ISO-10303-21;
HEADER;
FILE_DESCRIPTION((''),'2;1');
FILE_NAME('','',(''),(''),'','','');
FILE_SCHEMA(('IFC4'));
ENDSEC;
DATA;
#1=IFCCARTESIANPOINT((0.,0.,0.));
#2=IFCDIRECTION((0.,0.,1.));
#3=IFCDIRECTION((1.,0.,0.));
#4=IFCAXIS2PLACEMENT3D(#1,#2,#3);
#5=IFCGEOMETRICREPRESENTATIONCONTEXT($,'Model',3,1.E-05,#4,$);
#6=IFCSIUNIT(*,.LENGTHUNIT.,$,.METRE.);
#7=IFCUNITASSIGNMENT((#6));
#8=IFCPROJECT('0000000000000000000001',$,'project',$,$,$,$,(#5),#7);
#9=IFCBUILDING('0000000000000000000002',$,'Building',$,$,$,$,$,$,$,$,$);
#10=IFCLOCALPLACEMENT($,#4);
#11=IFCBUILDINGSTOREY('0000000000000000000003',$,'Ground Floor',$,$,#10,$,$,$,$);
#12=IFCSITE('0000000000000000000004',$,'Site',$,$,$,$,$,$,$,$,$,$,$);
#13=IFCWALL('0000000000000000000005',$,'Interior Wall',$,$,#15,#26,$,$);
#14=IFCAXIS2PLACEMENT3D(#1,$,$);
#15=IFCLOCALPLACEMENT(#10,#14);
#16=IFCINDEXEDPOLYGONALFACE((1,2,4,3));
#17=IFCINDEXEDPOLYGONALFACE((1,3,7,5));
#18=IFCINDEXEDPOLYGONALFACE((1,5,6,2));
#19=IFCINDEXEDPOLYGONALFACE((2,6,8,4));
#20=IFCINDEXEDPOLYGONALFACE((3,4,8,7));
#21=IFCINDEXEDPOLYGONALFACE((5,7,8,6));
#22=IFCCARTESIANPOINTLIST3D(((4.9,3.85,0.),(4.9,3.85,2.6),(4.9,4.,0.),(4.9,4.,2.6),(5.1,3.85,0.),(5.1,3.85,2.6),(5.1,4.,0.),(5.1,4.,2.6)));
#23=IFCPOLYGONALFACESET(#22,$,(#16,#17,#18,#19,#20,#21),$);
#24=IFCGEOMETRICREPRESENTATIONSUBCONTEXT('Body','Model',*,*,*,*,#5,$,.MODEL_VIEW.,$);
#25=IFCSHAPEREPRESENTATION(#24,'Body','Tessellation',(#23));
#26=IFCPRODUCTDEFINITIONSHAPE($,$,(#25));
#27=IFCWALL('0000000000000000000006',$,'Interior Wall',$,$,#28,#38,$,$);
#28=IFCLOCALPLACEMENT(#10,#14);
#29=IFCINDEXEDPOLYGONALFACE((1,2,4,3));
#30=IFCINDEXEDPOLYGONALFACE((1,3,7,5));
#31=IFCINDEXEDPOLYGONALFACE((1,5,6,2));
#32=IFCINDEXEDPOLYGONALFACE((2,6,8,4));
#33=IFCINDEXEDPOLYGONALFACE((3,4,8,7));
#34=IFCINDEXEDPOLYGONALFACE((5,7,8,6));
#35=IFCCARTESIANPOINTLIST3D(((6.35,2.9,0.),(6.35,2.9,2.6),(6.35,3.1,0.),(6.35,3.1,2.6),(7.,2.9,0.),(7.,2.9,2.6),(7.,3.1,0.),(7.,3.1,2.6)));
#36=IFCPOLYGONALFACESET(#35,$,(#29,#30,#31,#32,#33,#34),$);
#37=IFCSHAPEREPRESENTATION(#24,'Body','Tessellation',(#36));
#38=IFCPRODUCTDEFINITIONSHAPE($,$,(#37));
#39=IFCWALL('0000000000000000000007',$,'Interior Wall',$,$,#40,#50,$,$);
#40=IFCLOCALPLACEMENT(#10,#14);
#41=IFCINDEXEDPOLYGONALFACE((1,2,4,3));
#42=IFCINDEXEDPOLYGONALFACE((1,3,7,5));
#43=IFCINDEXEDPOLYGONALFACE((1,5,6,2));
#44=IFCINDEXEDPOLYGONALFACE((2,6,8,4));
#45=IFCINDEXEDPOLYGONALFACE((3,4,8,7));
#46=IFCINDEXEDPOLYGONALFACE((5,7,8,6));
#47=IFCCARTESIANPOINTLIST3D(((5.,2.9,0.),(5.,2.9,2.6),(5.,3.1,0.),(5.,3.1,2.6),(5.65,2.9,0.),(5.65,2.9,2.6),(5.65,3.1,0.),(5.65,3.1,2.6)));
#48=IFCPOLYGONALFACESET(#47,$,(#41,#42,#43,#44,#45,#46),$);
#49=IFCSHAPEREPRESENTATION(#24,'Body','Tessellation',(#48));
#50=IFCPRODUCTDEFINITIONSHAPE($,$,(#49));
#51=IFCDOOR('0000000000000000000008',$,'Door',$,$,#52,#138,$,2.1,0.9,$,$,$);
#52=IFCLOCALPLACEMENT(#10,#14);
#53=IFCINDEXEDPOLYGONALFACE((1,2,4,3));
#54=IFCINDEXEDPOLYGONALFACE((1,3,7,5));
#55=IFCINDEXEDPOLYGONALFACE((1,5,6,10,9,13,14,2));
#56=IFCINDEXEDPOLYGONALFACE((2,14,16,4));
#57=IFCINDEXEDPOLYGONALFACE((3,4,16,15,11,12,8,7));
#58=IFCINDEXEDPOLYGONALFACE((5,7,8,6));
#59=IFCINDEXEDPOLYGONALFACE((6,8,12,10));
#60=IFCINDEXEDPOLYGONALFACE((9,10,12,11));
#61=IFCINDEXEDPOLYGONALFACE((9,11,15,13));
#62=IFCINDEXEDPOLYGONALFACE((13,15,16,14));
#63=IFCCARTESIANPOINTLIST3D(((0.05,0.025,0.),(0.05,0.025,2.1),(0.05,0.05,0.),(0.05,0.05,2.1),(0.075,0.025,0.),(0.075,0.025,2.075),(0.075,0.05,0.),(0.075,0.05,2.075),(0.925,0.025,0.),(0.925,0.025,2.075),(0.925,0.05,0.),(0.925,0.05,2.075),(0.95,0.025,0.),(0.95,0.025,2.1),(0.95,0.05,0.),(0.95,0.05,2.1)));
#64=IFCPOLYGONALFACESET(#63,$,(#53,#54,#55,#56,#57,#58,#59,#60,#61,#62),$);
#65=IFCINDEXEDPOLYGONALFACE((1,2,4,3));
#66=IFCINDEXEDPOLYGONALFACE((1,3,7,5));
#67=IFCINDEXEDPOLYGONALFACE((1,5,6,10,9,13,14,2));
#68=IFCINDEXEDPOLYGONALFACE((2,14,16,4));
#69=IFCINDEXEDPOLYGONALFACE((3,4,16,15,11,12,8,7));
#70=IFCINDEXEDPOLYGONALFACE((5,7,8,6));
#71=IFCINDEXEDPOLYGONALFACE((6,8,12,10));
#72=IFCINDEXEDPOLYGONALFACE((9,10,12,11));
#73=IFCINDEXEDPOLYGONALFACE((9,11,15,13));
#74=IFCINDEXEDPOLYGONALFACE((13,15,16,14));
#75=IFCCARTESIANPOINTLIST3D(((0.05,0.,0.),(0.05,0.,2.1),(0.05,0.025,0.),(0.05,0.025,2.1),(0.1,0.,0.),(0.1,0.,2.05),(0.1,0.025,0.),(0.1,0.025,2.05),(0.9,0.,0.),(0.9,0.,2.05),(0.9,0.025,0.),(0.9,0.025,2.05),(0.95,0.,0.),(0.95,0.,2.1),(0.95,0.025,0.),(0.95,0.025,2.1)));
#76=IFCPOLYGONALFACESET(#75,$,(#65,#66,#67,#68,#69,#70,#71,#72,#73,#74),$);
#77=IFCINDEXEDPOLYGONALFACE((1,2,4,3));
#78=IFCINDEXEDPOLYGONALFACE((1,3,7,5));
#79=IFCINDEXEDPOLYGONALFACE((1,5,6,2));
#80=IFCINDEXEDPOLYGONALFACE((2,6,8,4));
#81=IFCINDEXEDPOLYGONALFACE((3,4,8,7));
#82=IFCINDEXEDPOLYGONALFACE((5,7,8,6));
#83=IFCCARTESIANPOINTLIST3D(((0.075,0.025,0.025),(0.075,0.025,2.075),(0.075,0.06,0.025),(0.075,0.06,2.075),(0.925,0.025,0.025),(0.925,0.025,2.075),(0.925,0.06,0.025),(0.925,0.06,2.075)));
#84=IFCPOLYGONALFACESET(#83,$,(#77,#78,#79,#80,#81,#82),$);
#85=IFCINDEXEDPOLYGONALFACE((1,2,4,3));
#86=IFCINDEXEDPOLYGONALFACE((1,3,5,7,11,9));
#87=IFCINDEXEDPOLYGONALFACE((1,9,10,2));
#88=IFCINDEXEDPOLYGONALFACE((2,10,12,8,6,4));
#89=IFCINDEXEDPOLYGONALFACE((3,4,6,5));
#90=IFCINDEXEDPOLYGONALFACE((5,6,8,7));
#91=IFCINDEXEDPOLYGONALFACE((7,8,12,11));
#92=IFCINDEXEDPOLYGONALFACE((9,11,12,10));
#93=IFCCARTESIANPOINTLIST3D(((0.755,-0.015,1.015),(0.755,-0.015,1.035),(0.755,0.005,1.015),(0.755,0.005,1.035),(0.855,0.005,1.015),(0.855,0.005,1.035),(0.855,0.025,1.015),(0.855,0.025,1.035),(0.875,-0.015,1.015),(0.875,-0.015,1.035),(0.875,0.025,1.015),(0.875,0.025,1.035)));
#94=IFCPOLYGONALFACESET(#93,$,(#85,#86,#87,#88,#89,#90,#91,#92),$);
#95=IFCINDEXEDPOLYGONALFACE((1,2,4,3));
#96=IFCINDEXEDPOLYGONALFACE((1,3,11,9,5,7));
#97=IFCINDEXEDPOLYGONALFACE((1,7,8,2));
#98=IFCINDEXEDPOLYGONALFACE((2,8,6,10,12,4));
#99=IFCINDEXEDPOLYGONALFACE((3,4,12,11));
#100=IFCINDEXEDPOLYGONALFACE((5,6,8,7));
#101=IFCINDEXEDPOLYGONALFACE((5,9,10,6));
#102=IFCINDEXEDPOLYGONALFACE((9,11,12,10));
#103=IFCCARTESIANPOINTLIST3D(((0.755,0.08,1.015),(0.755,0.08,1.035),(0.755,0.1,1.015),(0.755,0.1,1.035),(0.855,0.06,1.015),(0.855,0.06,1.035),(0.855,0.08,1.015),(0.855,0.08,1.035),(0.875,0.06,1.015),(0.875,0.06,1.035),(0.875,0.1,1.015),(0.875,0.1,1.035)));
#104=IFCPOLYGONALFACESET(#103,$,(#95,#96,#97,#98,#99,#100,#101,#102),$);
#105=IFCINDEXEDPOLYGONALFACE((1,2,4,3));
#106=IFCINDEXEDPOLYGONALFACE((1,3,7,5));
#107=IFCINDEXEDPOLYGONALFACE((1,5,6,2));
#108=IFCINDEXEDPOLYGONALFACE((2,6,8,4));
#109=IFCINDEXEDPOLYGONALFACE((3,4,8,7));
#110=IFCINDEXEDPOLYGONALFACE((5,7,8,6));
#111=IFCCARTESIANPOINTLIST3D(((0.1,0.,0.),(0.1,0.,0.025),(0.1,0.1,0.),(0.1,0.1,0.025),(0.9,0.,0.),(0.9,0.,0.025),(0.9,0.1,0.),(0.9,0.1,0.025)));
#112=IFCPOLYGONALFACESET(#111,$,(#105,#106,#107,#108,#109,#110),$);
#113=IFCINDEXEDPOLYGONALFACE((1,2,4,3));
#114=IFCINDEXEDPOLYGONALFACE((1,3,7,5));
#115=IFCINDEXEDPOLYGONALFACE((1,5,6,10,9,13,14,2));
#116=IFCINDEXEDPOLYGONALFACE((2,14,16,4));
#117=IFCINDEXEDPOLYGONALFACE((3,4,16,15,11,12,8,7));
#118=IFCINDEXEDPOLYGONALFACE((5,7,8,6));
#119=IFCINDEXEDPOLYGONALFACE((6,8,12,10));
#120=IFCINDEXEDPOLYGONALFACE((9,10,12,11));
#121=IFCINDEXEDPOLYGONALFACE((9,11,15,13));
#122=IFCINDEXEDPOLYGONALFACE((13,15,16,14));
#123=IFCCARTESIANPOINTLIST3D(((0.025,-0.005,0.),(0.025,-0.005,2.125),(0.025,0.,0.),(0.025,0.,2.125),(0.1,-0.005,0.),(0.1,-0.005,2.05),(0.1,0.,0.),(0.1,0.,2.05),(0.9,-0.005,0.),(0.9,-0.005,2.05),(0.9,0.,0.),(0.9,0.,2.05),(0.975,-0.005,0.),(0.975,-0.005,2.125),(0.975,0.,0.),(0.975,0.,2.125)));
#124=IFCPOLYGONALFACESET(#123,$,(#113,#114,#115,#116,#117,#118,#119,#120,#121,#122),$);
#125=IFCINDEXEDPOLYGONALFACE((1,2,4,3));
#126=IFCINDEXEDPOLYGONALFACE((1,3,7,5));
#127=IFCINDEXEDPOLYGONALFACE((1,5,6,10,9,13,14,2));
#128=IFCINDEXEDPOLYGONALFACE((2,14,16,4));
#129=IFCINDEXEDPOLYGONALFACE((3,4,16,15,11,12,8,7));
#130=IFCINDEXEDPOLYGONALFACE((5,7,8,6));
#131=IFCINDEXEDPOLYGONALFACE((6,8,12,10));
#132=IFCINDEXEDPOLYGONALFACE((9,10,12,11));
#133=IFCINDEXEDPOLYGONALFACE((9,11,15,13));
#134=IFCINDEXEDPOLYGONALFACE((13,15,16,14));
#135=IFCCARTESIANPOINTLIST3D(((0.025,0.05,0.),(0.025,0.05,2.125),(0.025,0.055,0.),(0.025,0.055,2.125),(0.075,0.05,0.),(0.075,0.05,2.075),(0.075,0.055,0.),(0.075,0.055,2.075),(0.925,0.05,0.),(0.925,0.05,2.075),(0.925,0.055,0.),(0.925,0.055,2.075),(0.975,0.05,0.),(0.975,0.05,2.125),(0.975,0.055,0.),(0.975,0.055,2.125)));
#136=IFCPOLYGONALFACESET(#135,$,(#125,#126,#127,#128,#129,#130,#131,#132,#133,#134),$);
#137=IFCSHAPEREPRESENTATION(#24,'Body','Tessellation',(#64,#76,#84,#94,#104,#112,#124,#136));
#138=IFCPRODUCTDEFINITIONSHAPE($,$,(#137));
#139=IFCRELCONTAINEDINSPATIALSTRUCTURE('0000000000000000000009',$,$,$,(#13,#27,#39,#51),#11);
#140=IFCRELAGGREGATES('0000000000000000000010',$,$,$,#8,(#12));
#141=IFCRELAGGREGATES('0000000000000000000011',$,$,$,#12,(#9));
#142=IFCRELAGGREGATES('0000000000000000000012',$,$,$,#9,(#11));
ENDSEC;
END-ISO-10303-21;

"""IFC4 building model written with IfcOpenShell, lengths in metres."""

from ifc_helpers import new_model, si_unit, frame, origin_with_axes, place, context, subcontext, project, spatial, line, indexed_curve, outline, extrude, element, save


model = new_model("IFC4")

# Units and contexts
model_context = context("Model", 3, precision=1e-05, world=origin_with_axes())
body_context = subcontext(model_context, "Body", "Model", "MODEL_VIEW")
ifc_project = project(units=[si_unit("LENGTHUNIT", "METRE")], contexts=[model_context])

# Site, building, storey
site = spatial("IfcSite", under=ifc_project, Name="Site")
building = spatial("IfcBuilding", under=site, Name="Building")
storey_placement = place(None, origin_with_axes())
storey = spatial("IfcBuildingStorey", under=building, at=storey_placement, Name="Ground Floor")

# Walls
for number, where, z_axis, x_axis, name in (
    (1, (5.0, 3.85, 0.0), (0.0, 0.0, 1.0), (0.0, 1.0, 0.0), "Interior Wall"),
):
    element("IfcWall", number, at=place(storey_placement, frame(where, z_axis=z_axis, x_axis=x_axis)), inside=storey, Name=name, context=body_context, shape_type="SweptSolid", body=[
        extrude(outline(indexed_curve([(0.0, 0.0), (0.0, 0.2), (0.15, 0.2), (0.15, 0.0), (0.0, 0.0)], self_intersect=False)), frame((0.0, -0.1, 0.0), z_axis=(0.0, 0.0, 1.0), x_axis=(1.0, 0.0, 0.0)), (0.0, 0.0, 1.0), 2.6),
    ])
for number, where, z_axis, x_axis, name in (
    (2, (7.0, 3.0, 0.0), (0.0, 0.0, 1.0), (-1.0, 0.0, 0.0), "Interior Wall"),
    (3, (5.65, 3.0, 0.0), (0.0, 0.0, 1.0), (-1.0, 0.0, 0.0), "Interior Wall"),
):
    element("IfcWall", number, at=place(storey_placement, frame(where, z_axis=z_axis, x_axis=x_axis)), inside=storey, Name=name, context=body_context, shape_type="SweptSolid", body=[
        extrude(outline(indexed_curve([(0.0, 0.0), (0.0, 0.2), (0.65, 0.2), (0.65, 0.0), (0.0, 0.0)], self_intersect=False)), frame((0.0, -0.1, 0.0), z_axis=(0.0, 0.0, 1.0), x_axis=(1.0, 0.0, 0.0)), (0.0, 0.0, 1.0), 2.6),
    ])

# Door
door_1_placement = place(storey_placement, frame((0.05, 0.0, 0.0), z_axis=(0.0, 0.0, 1.0), x_axis=(1.0, 0.0, 0.0)))
element("IfcDoor", 4, at=door_1_placement, inside=storey, Name="Door", OverallHeight=2.1, OverallWidth=0.9, context=body_context, shape_type="SweptSolid", body=[
    extrude(outline(indexed_curve([(0.0, 0.0), (0.0, 2.1), (0.9, 2.1), (0.9, 0.0), (0.875, 0.0), (0.875, 2.075), (0.025, 2.075), (0.025, 0.0)], segments=[line(1, 2, 3, 4, 5, 6, 7, 8, 1)])), frame((0.0, 0.025, 0.0), z_axis=(0.0, -1.0, 0.0), x_axis=(1.0, 0.0, 0.0)), (0.0, 0.0, -1.0), 0.025),
    extrude(outline(indexed_curve([(0.0, 0.0), (0.0, 2.1), (0.9, 2.1), (0.9, 0.0), (0.85, 0.0), (0.85, 2.05), (0.05, 2.05), (0.05, 0.0)], segments=[line(1, 2, 3, 4, 5, 6, 7, 8, 1)])), frame((0.0, 0.0, 0.0), z_axis=(0.0, -1.0, 0.0), x_axis=(1.0, 0.0, 0.0)), (0.0, 0.0, -1.0), 0.025),
    extrude(outline(indexed_curve([(0.0, 0.0), (0.85, 0.0), (0.85, 0.035), (0.0, 0.035)], segments=[line(1, 2, 3, 4, 1)])), frame((0.025, 0.025, 0.025), z_axis=(0.0, 0.0, 1.0), x_axis=(1.0, 0.0, 0.0)), (0.0, 0.0, 1.0), 2.05),
    extrude(outline(indexed_curve([(0.0, 0.0), (0.0, -0.04), (-0.12, -0.04), (-0.12, -0.02), (-0.02, -0.02), (-0.02, 0.0)], segments=[line(1, 2, 3, 4, 5, 6, 1)])), frame((0.825, 0.025, 1.015), z_axis=(0.0, 0.0, 1.0), x_axis=(1.0, 0.0, 0.0)), (0.0, 0.0, 1.0), 0.02),
    extrude(outline(indexed_curve([(0.0, 0.0), (0.0, 0.04), (-0.12, 0.04), (-0.12, 0.02), (-0.02, 0.02), (-0.02, 0.0)], segments=[line(1, 2, 3, 4, 5, 6, 1)])), frame((0.825, 0.06, 1.015), z_axis=(0.0, 0.0, 1.0), x_axis=(1.0, 0.0, 0.0)), (0.0, 0.0, 1.0), 0.02),
    extrude(outline(indexed_curve([(0.0, 0.0), (0.8, 0.0), (0.8, 0.1), (0.0, 0.1)], segments=[line(1, 2, 3, 4, 1)])), frame((0.05, 0.0, 0.0), z_axis=(0.0, 0.0, 1.0), x_axis=(1.0, 0.0, 0.0)), (0.0, 0.0, 1.0), 0.025),
    extrude(outline(indexed_curve([(0.0, 0.0), (0.0, 2.125), (0.95, 2.125), (0.95, 0.0), (0.875, 0.0), (0.875, 2.05), (0.075, 2.05), (0.075, 0.0)], segments=[line(1, 2, 3, 4, 5, 6, 7, 8, 1)])), frame((-0.025, -0.005, 0.0), z_axis=(0.0, -1.0, 0.0), x_axis=(1.0, 0.0, 0.0)), (0.0, 0.0, -1.0), 0.005),
    extrude(outline(indexed_curve([(0.0, 0.0), (0.0, 2.125), (0.95, 2.125), (0.95, 0.0), (0.9, 0.0), (0.9, 2.075), (0.05, 2.075), (0.05, 0.0)], segments=[line(1, 2, 3, 4, 5, 6, 7, 8, 1)])), frame((-0.025, 0.05, 0.0), z_axis=(0.0, -1.0, 0.0), x_axis=(1.0, 0.0, 0.0)), (0.0, 0.0, -1.0), 0.005),
])

save(model, "model.ifc")
